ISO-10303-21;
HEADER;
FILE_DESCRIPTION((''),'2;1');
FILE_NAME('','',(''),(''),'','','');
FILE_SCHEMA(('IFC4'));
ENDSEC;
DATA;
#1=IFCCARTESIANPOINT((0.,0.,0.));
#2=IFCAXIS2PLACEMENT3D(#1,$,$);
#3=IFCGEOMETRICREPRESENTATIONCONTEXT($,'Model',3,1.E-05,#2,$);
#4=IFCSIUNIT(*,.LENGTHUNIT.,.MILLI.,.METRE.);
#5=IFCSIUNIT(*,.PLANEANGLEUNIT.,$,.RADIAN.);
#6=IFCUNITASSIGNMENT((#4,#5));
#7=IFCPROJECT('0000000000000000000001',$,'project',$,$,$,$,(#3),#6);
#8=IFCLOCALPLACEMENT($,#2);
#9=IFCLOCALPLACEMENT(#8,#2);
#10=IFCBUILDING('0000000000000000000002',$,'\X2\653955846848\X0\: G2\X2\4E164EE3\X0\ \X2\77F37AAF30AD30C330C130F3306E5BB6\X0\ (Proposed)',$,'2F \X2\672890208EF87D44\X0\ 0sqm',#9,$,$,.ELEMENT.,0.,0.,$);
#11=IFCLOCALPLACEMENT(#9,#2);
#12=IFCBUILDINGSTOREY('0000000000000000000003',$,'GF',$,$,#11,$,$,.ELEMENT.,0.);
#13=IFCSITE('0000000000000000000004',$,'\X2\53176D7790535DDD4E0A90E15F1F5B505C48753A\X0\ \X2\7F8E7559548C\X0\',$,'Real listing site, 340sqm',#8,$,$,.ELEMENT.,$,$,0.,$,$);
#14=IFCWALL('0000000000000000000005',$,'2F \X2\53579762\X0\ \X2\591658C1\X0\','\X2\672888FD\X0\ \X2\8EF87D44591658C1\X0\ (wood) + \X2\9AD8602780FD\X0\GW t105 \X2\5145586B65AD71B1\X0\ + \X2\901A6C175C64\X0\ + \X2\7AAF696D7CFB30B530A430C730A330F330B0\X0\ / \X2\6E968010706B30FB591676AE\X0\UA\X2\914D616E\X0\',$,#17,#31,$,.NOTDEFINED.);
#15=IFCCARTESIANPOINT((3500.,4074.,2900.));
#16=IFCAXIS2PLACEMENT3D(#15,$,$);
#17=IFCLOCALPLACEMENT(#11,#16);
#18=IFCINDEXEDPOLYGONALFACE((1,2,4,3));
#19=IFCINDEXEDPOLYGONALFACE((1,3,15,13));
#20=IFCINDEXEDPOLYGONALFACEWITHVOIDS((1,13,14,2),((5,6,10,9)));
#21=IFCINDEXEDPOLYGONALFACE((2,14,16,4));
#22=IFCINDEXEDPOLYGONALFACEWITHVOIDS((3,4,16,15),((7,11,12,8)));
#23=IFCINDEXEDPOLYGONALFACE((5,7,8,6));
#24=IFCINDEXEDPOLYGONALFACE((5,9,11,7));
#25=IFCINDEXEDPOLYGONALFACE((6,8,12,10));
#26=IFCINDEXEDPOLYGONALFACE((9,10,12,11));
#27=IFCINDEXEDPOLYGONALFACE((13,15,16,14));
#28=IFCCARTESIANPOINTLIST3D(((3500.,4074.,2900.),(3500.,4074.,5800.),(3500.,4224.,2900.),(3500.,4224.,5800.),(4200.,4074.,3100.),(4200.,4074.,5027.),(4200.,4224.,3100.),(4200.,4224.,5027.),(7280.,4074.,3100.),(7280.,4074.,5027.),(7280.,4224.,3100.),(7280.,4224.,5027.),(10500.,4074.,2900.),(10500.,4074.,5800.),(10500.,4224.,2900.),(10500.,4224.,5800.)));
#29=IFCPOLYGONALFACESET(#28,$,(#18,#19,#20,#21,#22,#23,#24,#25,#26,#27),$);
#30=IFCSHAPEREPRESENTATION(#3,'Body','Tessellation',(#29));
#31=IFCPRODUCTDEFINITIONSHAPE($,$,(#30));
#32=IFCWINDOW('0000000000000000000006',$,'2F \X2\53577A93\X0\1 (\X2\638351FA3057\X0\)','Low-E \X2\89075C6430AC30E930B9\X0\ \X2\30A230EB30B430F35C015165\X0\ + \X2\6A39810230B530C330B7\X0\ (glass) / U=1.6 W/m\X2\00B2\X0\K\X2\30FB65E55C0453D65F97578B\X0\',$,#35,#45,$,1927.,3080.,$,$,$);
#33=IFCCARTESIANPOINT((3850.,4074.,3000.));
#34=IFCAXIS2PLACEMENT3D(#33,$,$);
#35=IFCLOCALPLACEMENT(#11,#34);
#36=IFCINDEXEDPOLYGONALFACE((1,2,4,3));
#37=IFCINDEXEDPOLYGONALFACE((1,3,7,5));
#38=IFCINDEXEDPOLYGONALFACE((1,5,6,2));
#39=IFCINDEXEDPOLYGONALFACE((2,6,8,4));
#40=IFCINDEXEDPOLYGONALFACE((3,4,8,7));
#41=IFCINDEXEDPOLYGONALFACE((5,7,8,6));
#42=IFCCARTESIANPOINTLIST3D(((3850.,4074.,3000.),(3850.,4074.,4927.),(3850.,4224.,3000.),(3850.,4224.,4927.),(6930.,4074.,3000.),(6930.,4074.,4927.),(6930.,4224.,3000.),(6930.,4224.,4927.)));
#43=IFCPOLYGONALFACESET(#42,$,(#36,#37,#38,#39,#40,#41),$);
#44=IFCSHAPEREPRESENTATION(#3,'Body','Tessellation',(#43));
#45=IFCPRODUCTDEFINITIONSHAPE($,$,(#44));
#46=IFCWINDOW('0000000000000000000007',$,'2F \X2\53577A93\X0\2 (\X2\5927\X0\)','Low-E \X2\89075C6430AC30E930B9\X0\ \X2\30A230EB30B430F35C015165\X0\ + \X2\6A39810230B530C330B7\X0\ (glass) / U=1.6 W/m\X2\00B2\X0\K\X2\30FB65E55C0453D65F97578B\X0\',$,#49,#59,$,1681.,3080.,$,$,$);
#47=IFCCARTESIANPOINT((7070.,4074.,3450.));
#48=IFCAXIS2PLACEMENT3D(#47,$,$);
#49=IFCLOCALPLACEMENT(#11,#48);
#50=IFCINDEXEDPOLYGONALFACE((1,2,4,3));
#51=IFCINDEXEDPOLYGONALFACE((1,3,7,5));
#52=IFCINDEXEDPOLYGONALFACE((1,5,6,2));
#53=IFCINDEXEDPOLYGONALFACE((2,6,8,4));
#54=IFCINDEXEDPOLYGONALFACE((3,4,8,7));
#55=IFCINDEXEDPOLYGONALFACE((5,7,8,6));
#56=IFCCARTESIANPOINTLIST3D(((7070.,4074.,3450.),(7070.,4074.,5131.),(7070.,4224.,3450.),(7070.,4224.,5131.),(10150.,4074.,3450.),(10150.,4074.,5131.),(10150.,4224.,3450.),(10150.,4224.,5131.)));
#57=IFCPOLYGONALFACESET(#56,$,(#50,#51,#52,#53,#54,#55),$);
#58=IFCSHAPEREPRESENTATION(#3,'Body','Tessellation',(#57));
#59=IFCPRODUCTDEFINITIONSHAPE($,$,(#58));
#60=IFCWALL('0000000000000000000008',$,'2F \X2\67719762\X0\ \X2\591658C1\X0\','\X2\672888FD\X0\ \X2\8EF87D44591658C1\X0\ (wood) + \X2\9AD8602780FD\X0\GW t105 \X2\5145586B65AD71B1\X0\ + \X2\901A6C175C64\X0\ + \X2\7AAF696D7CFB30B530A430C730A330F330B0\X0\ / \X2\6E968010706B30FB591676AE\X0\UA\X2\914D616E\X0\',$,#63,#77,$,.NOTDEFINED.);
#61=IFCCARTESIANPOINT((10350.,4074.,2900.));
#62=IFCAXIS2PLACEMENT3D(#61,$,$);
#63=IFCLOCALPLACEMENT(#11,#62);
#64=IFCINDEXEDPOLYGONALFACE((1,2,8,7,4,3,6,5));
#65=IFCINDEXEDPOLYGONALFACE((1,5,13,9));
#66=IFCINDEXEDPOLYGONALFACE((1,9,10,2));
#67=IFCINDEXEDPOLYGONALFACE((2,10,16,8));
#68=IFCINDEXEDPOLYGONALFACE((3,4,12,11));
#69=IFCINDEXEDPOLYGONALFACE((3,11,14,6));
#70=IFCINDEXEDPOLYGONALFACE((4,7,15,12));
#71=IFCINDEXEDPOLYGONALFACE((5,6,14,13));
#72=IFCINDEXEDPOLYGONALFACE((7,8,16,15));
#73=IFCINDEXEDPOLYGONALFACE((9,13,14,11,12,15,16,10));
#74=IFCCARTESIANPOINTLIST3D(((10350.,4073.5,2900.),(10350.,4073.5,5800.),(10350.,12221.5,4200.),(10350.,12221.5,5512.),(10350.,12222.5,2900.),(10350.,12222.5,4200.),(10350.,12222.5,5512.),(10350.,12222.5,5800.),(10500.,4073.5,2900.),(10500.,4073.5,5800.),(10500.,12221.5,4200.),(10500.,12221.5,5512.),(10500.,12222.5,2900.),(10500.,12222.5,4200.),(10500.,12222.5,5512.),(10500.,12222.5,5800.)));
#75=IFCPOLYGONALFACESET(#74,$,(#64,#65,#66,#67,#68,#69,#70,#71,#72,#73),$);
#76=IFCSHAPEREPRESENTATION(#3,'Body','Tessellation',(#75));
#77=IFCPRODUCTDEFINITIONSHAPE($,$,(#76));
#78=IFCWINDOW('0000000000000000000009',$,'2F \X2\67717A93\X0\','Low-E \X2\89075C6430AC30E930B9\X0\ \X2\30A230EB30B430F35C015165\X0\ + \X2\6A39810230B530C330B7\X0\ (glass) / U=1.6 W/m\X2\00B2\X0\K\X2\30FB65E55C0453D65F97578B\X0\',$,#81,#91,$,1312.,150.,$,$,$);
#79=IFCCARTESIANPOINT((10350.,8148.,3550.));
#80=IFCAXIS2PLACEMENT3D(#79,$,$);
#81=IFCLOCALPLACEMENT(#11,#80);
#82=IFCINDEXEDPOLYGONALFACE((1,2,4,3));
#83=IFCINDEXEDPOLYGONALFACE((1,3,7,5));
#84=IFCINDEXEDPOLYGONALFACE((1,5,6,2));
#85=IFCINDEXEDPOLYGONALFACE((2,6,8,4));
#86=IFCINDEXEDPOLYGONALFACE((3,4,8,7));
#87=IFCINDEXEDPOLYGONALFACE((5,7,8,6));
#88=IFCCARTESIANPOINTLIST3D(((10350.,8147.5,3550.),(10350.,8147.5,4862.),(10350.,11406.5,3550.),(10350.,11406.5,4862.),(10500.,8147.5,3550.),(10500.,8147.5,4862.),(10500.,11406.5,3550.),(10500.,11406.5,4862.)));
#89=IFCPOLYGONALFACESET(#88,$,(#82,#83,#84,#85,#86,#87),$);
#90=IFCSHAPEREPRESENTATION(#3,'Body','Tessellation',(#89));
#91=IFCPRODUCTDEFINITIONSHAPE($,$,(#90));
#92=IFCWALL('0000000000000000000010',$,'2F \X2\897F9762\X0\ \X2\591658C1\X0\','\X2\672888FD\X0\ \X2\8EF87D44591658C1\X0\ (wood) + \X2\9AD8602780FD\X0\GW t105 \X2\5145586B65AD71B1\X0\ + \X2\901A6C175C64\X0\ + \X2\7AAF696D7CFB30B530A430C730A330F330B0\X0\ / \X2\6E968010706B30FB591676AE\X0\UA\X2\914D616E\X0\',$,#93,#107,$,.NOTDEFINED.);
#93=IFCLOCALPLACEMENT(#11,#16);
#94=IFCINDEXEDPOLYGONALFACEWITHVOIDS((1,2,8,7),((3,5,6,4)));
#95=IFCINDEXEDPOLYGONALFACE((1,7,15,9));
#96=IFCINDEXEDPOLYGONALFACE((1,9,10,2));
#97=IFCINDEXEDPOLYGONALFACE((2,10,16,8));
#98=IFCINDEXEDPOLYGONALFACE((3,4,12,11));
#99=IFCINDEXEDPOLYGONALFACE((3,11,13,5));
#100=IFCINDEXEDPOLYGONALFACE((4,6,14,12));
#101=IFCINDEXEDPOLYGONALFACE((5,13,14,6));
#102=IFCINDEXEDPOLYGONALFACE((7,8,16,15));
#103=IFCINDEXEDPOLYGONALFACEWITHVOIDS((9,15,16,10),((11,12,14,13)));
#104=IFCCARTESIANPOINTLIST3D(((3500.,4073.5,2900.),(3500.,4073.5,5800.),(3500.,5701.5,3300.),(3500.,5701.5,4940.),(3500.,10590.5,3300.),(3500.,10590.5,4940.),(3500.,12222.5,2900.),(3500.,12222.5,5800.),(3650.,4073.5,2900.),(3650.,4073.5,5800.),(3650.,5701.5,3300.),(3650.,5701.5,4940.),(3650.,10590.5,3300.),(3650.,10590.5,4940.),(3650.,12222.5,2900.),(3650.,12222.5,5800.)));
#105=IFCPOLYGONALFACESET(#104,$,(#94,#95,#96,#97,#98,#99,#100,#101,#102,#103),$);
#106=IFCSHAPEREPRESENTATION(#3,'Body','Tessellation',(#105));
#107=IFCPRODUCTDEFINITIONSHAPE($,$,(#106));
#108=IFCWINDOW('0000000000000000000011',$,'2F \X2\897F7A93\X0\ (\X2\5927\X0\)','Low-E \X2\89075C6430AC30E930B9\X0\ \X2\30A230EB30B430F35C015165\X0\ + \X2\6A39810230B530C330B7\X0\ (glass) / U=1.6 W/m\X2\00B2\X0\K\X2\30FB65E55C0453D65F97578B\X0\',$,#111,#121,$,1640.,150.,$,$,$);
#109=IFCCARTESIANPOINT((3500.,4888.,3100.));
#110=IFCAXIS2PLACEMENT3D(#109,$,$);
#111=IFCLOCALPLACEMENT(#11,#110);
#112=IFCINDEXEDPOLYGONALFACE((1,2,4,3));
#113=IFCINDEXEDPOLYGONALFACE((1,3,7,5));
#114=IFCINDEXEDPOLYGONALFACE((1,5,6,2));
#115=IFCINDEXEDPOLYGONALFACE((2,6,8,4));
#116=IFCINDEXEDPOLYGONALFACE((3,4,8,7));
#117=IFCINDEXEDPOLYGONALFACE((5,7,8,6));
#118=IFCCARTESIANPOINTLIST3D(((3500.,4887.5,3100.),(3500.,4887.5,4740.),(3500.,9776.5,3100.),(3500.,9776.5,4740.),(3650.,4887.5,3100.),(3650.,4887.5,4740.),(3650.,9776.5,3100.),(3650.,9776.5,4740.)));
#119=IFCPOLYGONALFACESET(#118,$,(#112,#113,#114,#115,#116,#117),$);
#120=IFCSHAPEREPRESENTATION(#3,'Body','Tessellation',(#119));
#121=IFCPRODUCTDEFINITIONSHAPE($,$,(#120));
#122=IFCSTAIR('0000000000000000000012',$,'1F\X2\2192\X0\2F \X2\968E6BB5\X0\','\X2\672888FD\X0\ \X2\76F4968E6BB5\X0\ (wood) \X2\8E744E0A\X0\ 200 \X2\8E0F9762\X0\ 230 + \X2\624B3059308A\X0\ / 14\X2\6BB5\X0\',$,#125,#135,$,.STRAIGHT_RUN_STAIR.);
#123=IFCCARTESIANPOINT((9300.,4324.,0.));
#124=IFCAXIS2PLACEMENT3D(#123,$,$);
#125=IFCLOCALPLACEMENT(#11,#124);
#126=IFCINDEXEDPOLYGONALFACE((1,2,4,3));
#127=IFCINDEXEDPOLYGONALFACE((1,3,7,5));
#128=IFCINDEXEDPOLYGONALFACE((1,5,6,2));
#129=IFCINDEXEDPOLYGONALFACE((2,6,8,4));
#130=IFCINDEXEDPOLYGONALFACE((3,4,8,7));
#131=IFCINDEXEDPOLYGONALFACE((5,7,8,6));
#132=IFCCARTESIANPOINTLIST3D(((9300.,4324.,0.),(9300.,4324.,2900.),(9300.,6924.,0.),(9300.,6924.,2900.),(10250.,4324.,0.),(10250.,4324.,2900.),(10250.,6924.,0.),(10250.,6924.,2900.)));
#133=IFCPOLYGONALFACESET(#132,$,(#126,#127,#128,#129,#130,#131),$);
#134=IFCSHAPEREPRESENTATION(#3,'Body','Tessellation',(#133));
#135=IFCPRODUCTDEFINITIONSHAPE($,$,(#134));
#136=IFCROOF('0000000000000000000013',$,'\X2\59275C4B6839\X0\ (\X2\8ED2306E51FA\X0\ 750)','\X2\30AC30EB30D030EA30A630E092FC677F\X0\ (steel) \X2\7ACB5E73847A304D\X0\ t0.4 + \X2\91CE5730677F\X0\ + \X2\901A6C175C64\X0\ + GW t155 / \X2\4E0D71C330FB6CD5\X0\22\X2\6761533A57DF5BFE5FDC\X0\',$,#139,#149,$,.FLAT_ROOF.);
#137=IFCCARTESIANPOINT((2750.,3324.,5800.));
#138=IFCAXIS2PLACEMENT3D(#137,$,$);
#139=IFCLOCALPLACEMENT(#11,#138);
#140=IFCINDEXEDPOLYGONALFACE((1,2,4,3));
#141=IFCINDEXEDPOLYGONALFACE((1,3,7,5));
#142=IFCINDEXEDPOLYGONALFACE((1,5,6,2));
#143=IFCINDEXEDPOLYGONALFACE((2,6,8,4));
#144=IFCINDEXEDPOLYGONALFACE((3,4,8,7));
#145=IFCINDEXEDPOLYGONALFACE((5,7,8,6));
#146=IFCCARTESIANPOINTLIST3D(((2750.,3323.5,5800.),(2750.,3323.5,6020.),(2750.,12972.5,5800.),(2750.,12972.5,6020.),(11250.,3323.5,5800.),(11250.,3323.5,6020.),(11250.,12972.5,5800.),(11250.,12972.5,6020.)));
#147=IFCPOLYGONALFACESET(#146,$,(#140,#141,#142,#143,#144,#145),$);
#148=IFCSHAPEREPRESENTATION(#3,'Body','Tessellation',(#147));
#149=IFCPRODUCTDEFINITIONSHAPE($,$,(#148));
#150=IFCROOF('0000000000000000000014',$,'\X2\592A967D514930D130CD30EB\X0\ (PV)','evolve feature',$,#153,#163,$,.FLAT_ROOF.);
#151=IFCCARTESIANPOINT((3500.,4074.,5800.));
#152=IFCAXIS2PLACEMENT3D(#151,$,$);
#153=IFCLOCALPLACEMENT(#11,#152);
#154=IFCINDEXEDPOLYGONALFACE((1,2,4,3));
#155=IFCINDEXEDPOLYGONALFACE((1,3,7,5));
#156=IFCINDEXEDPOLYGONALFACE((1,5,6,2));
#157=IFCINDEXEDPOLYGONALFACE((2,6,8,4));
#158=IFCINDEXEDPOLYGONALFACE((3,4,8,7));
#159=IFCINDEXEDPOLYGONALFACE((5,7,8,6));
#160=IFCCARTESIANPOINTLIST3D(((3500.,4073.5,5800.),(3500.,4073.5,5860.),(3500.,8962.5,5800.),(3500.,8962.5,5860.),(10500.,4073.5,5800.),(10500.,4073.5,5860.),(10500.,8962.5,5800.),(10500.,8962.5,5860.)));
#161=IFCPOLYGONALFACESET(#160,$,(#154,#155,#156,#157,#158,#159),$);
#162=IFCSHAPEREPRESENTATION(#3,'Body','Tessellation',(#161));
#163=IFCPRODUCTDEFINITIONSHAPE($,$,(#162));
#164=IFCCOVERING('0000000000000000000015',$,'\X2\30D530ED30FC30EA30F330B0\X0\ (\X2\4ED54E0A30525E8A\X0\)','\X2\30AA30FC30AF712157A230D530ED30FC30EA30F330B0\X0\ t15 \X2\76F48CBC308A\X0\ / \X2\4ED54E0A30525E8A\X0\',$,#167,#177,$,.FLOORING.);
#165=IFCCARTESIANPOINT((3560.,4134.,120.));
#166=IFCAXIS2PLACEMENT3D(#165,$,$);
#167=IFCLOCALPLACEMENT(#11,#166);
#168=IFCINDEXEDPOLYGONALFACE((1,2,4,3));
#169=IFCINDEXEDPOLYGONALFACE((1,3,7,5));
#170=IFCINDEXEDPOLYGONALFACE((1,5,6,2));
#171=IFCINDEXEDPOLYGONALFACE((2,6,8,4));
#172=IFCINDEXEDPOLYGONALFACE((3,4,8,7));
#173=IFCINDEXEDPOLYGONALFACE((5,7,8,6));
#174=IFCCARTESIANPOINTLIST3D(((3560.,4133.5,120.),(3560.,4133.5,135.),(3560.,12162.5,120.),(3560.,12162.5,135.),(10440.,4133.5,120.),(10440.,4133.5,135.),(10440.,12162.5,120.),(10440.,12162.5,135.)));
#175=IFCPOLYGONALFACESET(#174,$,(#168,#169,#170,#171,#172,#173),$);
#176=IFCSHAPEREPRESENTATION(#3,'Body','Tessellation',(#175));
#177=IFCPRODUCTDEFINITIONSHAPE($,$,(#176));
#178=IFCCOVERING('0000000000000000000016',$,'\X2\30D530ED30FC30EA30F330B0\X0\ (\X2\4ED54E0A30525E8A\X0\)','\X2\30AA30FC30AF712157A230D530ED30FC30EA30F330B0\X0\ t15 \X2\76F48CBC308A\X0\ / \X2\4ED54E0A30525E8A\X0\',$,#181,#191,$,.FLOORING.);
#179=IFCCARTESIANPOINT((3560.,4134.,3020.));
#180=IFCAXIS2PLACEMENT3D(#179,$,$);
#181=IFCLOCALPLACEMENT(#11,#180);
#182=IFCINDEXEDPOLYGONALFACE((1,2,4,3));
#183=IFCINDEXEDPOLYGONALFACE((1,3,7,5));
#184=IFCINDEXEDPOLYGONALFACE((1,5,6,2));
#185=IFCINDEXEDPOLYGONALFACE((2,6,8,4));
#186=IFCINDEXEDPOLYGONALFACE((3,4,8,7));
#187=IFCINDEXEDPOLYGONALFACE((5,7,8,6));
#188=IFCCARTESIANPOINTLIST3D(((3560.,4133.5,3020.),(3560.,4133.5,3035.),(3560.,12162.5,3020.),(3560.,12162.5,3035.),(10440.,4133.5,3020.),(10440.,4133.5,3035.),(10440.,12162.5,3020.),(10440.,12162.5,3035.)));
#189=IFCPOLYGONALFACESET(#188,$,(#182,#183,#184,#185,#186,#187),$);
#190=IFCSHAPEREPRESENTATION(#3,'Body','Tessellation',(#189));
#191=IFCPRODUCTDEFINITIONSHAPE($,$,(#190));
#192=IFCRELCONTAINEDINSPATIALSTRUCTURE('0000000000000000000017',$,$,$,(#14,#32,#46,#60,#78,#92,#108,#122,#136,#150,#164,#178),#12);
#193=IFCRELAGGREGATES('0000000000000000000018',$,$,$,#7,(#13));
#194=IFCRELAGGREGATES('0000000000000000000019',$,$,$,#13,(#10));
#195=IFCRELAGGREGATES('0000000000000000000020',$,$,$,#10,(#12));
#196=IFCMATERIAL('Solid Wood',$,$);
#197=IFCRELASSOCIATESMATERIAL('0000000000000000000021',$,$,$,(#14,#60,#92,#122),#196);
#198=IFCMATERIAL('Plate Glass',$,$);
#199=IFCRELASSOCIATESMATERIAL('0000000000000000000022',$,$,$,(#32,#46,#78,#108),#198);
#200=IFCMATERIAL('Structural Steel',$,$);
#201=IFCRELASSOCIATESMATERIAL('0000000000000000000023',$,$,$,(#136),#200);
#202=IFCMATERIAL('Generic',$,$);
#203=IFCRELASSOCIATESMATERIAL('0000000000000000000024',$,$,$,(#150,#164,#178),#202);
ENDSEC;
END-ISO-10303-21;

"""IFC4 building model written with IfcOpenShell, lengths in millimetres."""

from ifc_helpers import new_model, si_unit, frame, frame_2d, origin, place, context, project, spatial, rectangle, extrude, material, element, fill, save


model = new_model("IFC4")

# Units and contexts
model_context = context("Model", 3, precision=1e-05, world=origin())
ifc_project = project(units=[si_unit("LENGTHUNIT", "METRE", prefix="MILLI"), si_unit("PLANEANGLEUNIT", "RADIAN")], contexts=[model_context])

# Site, building, storey
site_placement = place(None, origin())
site = spatial("IfcSite", under=ifc_project, at=site_placement, Name="北海道川上郡弟子屈町 美留和", ObjectType="Real listing site, 340sqm", CompositionType="ELEMENT", RefElevation=0.0)
building_placement = place(site_placement, origin())
building = spatial("IfcBuilding", under=site, at=building_placement, Name="改善案: G2世代 石窯キッチンの家 (Proposed)", ObjectType="2F 木造軸組 0sqm", CompositionType="ELEMENT", ElevationOfRefHeight=0.0, ElevationOfTerrain=0.0)
storey_placement = place(building_placement, origin())
storey = spatial("IfcBuildingStorey", under=building, at=storey_placement, Name="GF", CompositionType="ELEMENT", Elevation=0.0)

# Shared definitions
ifc_material_1 = material(Name="Solid Wood")
ifc_material_2 = material(Name="Generic")

# Shared definitions
ifc_material_3 = material(Name="Plate Glass")

# Wall, openings, windows
wall_1_placement = place(storey_placement, frame((3500.0, 4074.0, 2900.0)))
wall_1 = element("IfcWall", 1, at=wall_1_placement, inside=storey, material=ifc_material_1, Name="2F 南面 外壁", Description="木製 軸組外壁 (wood) + 高性能GW t105 充填断熱 + 通気層 + 窯業系サイディング / 準耐火・外皮UA配慮", PredefinedType="NOTDEFINED", context=model_context, shape_type="SweptSolid", body=[
    extrude(rectangle(XDim=7000.0, YDim=150.0, at=frame_2d((3500.0, 75.0))), frame((3500.0, 4074.0, 2900.0)), (0.0, 0.0, 1.0), 2900.0),
])
opening_1_placement = place(storey_placement, frame((3850.0, 4074.0, 3000.0)))
opening_1 = element("IfcOpeningElement", 2, at=opening_1_placement, cuts=wall_1, PredefinedType="NOTDEFINED", context=model_context, shape_type="SweptSolid", body=[
    extrude(rectangle(XDim=3080.0, YDim=150.0, at=frame_2d((1540.0, 75.0))), frame((3850.0, 4074.0, 3000.0)), (0.0, 0.0, 1.0), 1927.0),
])
opening_2_placement = place(storey_placement, frame((7070.0, 4074.0, 3450.0)))
opening_2 = element("IfcOpeningElement", 3, at=opening_2_placement, cuts=wall_1, PredefinedType="NOTDEFINED", context=model_context, shape_type="SweptSolid", body=[
    extrude(rectangle(XDim=3080.0, YDim=150.0, at=frame_2d((1540.0, 75.0))), frame((7070.0, 4074.0, 3450.0)), (0.0, 0.0, 1.0), 1681.0),
])
window_1_placement = place(storey_placement, frame((3850.0, 4074.0, 3000.0)))
window_1 = element("IfcWindow", 4, at=window_1_placement, inside=storey, material=ifc_material_3, Name="2F 南窓1 (掃出し)", Description="Low-E 複層ガラス アルゴン封入 + 樹脂サッシ (glass) / U=1.6 W/m²K・日射取得型", OverallHeight=1927.0, OverallWidth=3080.0, context=model_context, shape_type="SweptSolid", body=[
    extrude(rectangle(XDim=3080.0, YDim=150.0, at=frame_2d((1540.0, 75.0))), frame((3850.0, 4074.0, 3000.0)), (0.0, 0.0, 1.0), 1927.0),
])
fill(opening_1, window_1)
window_2_placement = place(storey_placement, frame((7070.0, 4074.0, 3450.0)))
window_2 = element("IfcWindow", 5, at=window_2_placement, inside=storey, material=ifc_material_3, Name="2F 南窓2 (大)", Description="Low-E 複層ガラス アルゴン封入 + 樹脂サッシ (glass) / U=1.6 W/m²K・日射取得型", OverallHeight=1681.0, OverallWidth=3080.0, context=model_context, shape_type="SweptSolid", body=[
    extrude(rectangle(XDim=3080.0, YDim=150.0, at=frame_2d((1540.0, 75.0))), frame((7070.0, 4074.0, 3450.0)), (0.0, 0.0, 1.0), 1681.0),
])
fill(opening_2, window_2)

# Walls, openings, windows
wall_2_placement = place(storey_placement, frame((10350.0, 4074.0, 2900.0)))
wall_2 = element("IfcWall", 6, at=wall_2_placement, inside=storey, material=ifc_material_1, Name="2F 東面 外壁", Description="木製 軸組外壁 (wood) + 高性能GW t105 充填断熱 + 通気層 + 窯業系サイディング / 準耐火・外皮UA配慮", PredefinedType="NOTDEFINED", context=model_context, shape_type="SweptSolid", body=[
    extrude(rectangle(XDim=150.0, YDim=8149.0, at=frame_2d((75.0, 4074.0))), frame((10350.0, 4074.0, 2900.0)), (0.0, 0.0, 1.0), 2900.0),
])
opening_3_placement = place(storey_placement, frame((10350.0, 8148.0, 3550.0)))
opening_3 = element("IfcOpeningElement", 7, at=opening_3_placement, cuts=wall_2, PredefinedType="NOTDEFINED", context=model_context, shape_type="SweptSolid", body=[
    extrude(rectangle(XDim=150.0, YDim=3259.0, at=frame_2d((75.0, 1629.0))), frame((10350.0, 8148.0, 3550.0)), (0.0, 0.0, 1.0), 1312.0),
])
window_3_placement = place(storey_placement, frame((10350.0, 8148.0, 3550.0)))
window_3 = element("IfcWindow", 8, at=window_3_placement, inside=storey, material=ifc_material_3, Name="2F 東窓", Description="Low-E 複層ガラス アルゴン封入 + 樹脂サッシ (glass) / U=1.6 W/m²K・日射取得型", OverallHeight=1312.0, OverallWidth=150.0, context=model_context, shape_type="SweptSolid", body=[
    extrude(rectangle(XDim=150.0, YDim=3259.0, at=frame_2d((75.0, 1629.0))), frame((10350.0, 8148.0, 3550.0)), (0.0, 0.0, 1.0), 1312.0),
])
fill(opening_3, window_3)
wall_3_placement = place(storey_placement, frame((3500.0, 4074.0, 2900.0)))
wall_3 = element("IfcWall", 9, at=wall_3_placement, inside=storey, material=ifc_material_1, Name="2F 西面 外壁", Description="木製 軸組外壁 (wood) + 高性能GW t105 充填断熱 + 通気層 + 窯業系サイディング / 準耐火・外皮UA配慮", PredefinedType="NOTDEFINED", context=model_context, shape_type="SweptSolid", body=[
    extrude(rectangle(XDim=150.0, YDim=8149.0, at=frame_2d((75.0, 4074.0))), frame((3500.0, 4074.0, 2900.0)), (0.0, 0.0, 1.0), 2900.0),
])
opening_4_placement = place(storey_placement, frame((3500.0, 4888.0, 3100.0)))
opening_4 = element("IfcOpeningElement", 10, at=opening_4_placement, cuts=wall_3, PredefinedType="NOTDEFINED", context=model_context, shape_type="SweptSolid", body=[
    extrude(rectangle(XDim=150.0, YDim=4889.0, at=frame_2d((75.0, 2444.0))), frame((3500.0, 4888.0, 3100.0)), (0.0, 0.0, 1.0), 1640.0),
])
window_4_placement = place(storey_placement, frame((3500.0, 4888.0, 3100.0)))
window_4 = element("IfcWindow", 11, at=window_4_placement, inside=storey, material=ifc_material_3, Name="2F 西窓 (大)", Description="Low-E 複層ガラス アルゴン封入 + 樹脂サッシ (glass) / U=1.6 W/m²K・日射取得型", OverallHeight=1640.0, OverallWidth=150.0, context=model_context, shape_type="SweptSolid", body=[
    extrude(rectangle(XDim=150.0, YDim=4889.0, at=frame_2d((75.0, 2444.0))), frame((3500.0, 4888.0, 3100.0)), (0.0, 0.0, 1.0), 1640.0),
])
fill(opening_4, window_4)

# Stair
stair_placement = place(storey_placement, frame((9300.0, 4324.0, 0.0)))
element("IfcStair", 12, at=stair_placement, inside=storey, material=ifc_material_1, Name="1F→2F 階段", Description="木製 直階段 (wood) 蹴上 200 踏面 230 + 手すり / 14段", PredefinedType="STRAIGHT_RUN_STAIR", context=model_context, shape_type="SweptSolid", body=[
    extrude(rectangle(XDim=950.0, YDim=2600.0, at=frame_2d((475.0, 1300.0))), frame((9300.0, 4324.0, 0.0)), (0.0, 0.0, 1.0), 2900.0),
])

# Roofs
ifc_material_4 = material(Name="Structural Steel")
roof_1_placement = place(storey_placement, frame((2750.0, 3324.0, 5800.0)))
element("IfcRoof", 13, at=roof_1_placement, inside=storey, material=ifc_material_4, Name="大屋根 (軒の出 750)", Description="ガルバリウム鋼板 (steel) 立平葺き t0.4 + 野地板 + 通気層 + GW t155 / 不燃・法22条区域対応", PredefinedType="FLAT_ROOF", context=model_context, shape_type="SweptSolid", body=[
    extrude(rectangle(XDim=8500.0, YDim=9649.0, at=frame_2d((4250.0, 4824.0))), frame((2750.0, 3324.0, 5800.0)), (0.0, 0.0, 1.0), 220.0),
])
roof_2_placement = place(storey_placement, frame((3500.0, 4074.0, 5800.0)))
element("IfcRoof", 14, at=roof_2_placement, inside=storey, material=ifc_material_2, Name="太陽光パネル (PV)", Description="evolve feature", PredefinedType="FLAT_ROOF", context=model_context, shape_type="SweptSolid", body=[
    extrude(rectangle(XDim=7000.0, YDim=4889.0, at=frame_2d((3500.0, 2444.0))), frame((3500.0, 4074.0, 5800.0)), (0.0, 0.0, 1.0), 60.0),
])

# Coverings
covering_1_placement = place(storey_placement, frame((3560.0, 4134.0, 120.0)))
element("IfcCovering", 15, at=covering_1_placement, inside=storey, material=ifc_material_2, Name="フローリング (仕上げ床)", Description="オーク無垢フローリング t15 直貼り / 仕上げ床", PredefinedType="FLOORING", context=model_context, shape_type="SweptSolid", body=[
    extrude(rectangle(XDim=6880.0, YDim=8029.0, at=frame_2d((3440.0, 4014.0))), frame((3560.0, 4134.0, 120.0)), (0.0, 0.0, 1.0), 15.0),
])
covering_2_placement = place(storey_placement, frame((3560.0, 4134.0, 3020.0)))
element("IfcCovering", 16, at=covering_2_placement, inside=storey, material=ifc_material_2, Name="フローリング (仕上げ床)", Description="オーク無垢フローリング t15 直貼り / 仕上げ床", PredefinedType="FLOORING", context=model_context, shape_type="SweptSolid", body=[
    extrude(rectangle(XDim=6880.0, YDim=8029.0, at=frame_2d((3440.0, 4014.0))), frame((3560.0, 4134.0, 3020.0)), (0.0, 0.0, 1.0), 15.0),
])

save(model, "model.ifc")
